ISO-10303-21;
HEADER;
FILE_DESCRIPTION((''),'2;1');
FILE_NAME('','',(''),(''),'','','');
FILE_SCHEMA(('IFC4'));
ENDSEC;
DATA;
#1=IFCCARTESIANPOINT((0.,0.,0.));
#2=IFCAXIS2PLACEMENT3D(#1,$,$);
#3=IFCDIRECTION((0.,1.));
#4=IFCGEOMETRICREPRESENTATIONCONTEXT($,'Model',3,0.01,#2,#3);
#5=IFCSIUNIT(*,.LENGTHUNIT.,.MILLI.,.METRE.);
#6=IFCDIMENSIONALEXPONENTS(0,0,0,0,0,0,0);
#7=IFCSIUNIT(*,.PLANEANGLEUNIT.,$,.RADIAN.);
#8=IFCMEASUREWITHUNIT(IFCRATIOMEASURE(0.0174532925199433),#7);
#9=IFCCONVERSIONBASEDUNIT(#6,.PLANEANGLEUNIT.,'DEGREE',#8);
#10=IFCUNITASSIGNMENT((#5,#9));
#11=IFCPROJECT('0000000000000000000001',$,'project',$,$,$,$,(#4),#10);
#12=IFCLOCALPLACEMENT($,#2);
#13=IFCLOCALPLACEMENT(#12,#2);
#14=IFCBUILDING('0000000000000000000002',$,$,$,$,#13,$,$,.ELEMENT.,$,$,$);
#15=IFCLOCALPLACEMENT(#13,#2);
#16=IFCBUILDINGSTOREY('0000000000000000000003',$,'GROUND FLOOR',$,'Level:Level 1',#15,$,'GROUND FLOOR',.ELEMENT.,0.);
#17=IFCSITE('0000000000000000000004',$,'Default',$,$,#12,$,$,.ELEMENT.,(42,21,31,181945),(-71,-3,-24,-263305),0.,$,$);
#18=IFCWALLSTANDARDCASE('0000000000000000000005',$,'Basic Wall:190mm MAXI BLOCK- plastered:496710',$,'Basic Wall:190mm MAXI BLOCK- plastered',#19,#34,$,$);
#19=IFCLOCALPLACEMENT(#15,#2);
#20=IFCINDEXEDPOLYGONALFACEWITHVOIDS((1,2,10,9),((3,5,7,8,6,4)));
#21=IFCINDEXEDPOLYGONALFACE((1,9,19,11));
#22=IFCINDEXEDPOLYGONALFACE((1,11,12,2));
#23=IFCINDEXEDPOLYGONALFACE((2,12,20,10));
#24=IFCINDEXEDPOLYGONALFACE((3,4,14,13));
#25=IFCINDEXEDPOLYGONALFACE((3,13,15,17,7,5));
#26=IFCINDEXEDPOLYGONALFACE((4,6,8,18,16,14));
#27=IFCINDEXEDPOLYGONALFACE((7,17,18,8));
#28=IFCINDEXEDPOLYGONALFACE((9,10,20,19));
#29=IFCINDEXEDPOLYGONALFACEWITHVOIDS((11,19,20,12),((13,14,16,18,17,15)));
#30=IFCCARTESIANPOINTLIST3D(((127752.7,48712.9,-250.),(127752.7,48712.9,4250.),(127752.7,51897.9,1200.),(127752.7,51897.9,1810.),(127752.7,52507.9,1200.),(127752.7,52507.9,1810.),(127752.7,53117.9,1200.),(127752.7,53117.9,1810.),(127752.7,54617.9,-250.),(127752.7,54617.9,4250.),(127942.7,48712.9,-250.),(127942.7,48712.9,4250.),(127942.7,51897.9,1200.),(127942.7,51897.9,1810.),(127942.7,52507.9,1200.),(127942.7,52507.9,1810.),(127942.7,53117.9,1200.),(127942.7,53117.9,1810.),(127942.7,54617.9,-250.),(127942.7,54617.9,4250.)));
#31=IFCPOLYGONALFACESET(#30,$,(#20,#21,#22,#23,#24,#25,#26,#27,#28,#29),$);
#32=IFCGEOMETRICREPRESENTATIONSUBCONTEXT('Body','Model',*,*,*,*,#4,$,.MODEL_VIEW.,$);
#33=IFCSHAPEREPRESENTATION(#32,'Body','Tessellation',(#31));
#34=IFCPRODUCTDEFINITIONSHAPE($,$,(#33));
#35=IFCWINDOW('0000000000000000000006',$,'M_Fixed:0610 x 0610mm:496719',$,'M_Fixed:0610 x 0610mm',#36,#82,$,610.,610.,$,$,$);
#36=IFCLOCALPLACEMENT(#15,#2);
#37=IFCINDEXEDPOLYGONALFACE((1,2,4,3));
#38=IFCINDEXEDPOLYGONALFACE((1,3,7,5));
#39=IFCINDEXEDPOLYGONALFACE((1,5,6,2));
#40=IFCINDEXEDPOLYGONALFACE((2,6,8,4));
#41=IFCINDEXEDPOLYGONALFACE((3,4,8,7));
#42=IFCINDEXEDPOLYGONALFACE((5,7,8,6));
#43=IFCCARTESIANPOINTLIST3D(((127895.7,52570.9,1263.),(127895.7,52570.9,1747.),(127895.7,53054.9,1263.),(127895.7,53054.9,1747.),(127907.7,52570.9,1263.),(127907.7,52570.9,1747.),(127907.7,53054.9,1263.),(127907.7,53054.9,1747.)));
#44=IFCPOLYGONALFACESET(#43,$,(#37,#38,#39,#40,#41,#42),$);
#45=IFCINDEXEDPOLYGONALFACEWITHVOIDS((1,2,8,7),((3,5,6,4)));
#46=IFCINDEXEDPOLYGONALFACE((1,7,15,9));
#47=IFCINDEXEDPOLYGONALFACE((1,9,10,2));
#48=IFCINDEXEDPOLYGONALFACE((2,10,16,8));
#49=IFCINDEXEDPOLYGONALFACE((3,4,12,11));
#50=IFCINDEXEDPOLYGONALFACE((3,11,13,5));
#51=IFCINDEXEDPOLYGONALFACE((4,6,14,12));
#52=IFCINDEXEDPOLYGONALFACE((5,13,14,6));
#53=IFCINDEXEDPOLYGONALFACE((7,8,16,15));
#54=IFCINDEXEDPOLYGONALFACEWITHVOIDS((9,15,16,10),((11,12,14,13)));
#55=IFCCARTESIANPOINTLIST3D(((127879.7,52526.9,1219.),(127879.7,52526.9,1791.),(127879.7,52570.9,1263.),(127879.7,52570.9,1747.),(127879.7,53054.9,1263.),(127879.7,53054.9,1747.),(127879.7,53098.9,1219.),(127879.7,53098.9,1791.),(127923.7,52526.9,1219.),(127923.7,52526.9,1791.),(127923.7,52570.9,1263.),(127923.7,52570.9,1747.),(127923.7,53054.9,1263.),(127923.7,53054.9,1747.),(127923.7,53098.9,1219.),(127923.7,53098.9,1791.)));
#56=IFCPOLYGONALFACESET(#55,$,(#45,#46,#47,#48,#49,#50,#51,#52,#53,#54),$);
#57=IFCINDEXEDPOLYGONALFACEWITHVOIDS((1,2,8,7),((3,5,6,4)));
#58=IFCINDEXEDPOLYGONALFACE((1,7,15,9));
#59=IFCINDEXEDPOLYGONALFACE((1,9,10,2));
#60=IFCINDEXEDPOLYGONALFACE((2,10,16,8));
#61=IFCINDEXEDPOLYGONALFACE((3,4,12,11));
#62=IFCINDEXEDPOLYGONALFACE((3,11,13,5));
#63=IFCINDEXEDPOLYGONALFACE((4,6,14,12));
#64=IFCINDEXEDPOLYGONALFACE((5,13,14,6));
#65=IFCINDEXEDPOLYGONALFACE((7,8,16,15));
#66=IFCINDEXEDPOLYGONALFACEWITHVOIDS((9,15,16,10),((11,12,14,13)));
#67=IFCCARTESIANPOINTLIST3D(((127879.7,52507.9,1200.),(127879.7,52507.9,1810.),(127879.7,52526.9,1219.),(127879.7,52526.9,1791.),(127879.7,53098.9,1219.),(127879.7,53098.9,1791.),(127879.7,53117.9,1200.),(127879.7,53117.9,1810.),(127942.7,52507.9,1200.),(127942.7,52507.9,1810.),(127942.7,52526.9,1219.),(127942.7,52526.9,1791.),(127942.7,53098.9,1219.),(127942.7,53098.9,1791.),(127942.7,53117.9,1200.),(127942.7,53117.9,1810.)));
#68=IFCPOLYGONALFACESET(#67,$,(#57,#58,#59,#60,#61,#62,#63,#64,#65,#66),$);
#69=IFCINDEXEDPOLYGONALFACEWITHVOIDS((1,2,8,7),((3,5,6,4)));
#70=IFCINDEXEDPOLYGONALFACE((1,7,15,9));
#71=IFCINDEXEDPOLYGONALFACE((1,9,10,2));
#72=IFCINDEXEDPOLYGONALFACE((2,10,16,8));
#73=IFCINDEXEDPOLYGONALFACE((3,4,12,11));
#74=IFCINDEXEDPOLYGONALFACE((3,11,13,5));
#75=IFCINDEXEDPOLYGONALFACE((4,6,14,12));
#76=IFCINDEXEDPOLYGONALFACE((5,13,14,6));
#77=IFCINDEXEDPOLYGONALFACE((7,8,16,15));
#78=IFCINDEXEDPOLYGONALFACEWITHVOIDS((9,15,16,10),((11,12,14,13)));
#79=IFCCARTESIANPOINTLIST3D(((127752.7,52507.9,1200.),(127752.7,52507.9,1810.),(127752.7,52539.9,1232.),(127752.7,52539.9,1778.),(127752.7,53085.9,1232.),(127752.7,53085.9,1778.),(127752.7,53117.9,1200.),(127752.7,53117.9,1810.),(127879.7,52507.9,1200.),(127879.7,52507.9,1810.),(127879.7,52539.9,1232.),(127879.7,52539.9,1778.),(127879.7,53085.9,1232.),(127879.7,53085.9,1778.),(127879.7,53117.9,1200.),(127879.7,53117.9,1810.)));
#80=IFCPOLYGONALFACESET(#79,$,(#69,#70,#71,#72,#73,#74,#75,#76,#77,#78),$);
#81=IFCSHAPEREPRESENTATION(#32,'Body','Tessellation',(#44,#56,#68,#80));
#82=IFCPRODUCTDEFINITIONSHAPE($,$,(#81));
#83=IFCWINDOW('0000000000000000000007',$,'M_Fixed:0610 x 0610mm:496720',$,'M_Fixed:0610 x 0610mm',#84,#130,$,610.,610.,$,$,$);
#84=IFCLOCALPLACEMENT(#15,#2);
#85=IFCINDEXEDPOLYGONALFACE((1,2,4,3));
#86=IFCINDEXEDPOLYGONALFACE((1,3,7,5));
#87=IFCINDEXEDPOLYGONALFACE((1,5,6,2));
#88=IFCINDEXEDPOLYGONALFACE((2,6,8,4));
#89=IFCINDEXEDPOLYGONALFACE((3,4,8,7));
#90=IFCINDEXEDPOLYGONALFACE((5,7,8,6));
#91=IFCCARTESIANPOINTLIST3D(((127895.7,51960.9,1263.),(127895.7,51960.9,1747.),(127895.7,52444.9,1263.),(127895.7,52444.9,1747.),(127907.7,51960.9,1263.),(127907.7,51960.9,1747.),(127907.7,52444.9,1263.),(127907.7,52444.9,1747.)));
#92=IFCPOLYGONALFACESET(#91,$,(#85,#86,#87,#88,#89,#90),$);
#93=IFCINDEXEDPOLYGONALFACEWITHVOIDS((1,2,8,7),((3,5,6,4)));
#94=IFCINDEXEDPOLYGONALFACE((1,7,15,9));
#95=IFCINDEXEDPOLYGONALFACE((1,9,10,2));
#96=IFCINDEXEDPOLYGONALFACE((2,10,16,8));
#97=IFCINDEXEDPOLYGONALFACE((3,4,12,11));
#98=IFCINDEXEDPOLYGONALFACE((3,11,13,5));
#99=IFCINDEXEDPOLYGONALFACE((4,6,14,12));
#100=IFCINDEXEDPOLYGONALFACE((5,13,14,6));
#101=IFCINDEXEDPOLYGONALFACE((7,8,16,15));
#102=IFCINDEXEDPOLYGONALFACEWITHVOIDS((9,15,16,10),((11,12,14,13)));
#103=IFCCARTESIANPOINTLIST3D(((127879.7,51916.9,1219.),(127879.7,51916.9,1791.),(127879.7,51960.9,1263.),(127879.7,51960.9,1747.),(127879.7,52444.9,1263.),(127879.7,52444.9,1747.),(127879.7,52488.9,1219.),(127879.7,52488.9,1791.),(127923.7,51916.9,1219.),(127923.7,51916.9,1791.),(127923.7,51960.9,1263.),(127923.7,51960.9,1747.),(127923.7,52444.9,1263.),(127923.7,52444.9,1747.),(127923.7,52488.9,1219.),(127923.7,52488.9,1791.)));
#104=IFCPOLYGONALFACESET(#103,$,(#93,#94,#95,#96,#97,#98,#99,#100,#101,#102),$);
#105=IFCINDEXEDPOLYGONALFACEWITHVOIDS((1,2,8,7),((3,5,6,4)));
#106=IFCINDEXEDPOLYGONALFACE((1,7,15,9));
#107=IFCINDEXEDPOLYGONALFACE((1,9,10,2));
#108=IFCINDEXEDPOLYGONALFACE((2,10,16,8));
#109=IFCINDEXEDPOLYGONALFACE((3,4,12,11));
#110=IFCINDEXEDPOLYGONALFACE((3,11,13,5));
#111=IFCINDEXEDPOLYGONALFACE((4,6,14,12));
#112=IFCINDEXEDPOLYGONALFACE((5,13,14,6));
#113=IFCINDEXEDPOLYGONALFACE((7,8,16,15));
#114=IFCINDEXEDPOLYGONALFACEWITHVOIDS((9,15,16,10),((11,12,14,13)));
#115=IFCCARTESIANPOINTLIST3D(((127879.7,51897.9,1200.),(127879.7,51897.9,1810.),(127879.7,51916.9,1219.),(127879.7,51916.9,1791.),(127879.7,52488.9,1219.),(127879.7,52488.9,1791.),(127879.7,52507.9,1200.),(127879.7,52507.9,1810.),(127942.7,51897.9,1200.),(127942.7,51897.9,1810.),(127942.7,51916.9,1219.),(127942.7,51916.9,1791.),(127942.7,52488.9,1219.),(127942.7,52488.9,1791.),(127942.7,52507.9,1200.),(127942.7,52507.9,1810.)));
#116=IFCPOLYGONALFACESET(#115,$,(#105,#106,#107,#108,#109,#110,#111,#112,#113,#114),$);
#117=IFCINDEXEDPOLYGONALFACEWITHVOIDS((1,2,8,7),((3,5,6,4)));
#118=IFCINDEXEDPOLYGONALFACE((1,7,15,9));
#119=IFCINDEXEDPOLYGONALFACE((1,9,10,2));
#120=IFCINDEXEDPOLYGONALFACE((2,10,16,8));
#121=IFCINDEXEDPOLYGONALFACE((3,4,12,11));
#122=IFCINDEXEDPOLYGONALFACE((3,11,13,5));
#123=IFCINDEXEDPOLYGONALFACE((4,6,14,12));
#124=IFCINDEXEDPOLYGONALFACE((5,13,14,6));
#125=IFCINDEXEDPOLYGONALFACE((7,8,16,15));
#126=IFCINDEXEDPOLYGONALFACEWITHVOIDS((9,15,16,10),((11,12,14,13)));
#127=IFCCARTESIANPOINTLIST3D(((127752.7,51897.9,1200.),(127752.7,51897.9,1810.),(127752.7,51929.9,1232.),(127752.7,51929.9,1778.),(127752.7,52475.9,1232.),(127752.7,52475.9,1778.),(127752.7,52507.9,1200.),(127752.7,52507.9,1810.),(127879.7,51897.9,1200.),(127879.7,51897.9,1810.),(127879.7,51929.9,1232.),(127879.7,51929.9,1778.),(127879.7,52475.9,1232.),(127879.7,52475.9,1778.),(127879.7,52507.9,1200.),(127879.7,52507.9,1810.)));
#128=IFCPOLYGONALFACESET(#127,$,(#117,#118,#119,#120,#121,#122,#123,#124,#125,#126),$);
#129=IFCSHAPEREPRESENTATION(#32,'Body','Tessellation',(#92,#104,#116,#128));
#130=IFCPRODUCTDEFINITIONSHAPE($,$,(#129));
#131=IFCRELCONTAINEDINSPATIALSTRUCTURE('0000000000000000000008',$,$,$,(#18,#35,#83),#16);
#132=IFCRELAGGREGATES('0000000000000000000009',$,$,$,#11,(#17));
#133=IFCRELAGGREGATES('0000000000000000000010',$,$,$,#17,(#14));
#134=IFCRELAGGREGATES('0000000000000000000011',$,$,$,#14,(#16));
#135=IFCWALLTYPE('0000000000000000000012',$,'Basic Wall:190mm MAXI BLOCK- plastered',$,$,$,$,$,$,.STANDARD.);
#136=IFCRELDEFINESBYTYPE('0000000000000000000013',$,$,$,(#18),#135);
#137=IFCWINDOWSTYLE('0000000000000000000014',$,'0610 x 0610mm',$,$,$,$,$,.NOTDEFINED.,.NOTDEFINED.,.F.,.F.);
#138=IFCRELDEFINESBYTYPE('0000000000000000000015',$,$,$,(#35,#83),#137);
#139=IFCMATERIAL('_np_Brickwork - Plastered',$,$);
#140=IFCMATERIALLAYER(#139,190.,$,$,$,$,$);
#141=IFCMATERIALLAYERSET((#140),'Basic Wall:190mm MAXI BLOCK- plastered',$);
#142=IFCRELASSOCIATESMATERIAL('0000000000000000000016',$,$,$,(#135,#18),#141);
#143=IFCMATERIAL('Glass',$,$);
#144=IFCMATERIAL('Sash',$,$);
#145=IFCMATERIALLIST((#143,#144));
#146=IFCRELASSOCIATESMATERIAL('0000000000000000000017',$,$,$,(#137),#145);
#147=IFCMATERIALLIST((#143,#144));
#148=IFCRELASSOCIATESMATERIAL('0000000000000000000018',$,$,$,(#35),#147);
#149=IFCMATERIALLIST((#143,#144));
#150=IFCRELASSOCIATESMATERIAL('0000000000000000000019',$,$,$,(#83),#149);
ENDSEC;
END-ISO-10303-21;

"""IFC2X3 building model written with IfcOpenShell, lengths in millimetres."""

from ifc_helpers import new_model, entity, si_unit, converted_unit, direction, frame, frame_2d, origin, place, context, subcontext, project, spatial, polyline, rectangle, outline, extrude, source, transform, mapped, material, material_list, layer, layer_set, layer_usage, type_object, type_shapes, element, fill, save


model = new_model("IFC2X3")

# Units and contexts
model_context = context("Model", 3, precision=0.01, world=origin(), true_north=direction((0.0, 1.0)))
body_context = subcontext(model_context, "Body", "Model", "MODEL_VIEW")
ifc_project = project(units=[si_unit("LENGTHUNIT", "METRE", prefix="MILLI"), converted_unit("PLANEANGLEUNIT", "DEGREE", entity("IfcRatioMeasure", 0.0174532925199433), si_unit("PLANEANGLEUNIT", "RADIAN"), dimensions=[0, 0, 0, 0, 0, 0, 0])], contexts=[model_context])

# Site, building, storey
site_placement = place(None, origin())
site = spatial("IfcSite", under=ifc_project, at=site_placement, Name="Default", CompositionType="ELEMENT", RefLatitude=(42, 21, 31, 181945), RefLongitude=(-71, -3, -24, -263305), RefElevation=0.0)
building_placement = place(site_placement, origin())
building = spatial("IfcBuilding", under=site, at=building_placement, CompositionType="ELEMENT")
storey_placement = place(building_placement, origin())
storey = spatial("IfcBuildingStorey", under=building, at=storey_placement, Name="GROUND FLOOR", ObjectType="Level:Level 1", LongName="GROUND FLOOR", CompositionType="ELEMENT", Elevation=0.0)

# Wall, openings, windows
ifc_material_1 = material(Name="_np_Brickwork - Plastered")
ifc_layer = layer(ifc_material_1, 190.0)
ifc_layer_set = layer_set([ifc_layer], Name="Basic Wall:190mm MAXI BLOCK- plastered")
wall_type = type_object("IfcWallType", Name="Basic Wall:190mm MAXI BLOCK- plastered", PredefinedType="STANDARD", material=ifc_layer_set)
ifc_material_2 = material(Name="Glass")
ifc_material_3 = material(Name="Sash")
ifc_material_list_1 = material_list([ifc_material_2, ifc_material_3])
window_style = type_object("IfcWindowStyle", Name="0610 x 0610mm", ConstructionType="NOTDEFINED", OperationType="NOTDEFINED", ParameterTakesPrecedence=False, Sizeable=False, material=ifc_material_list_1)
shared_shape = source(origin(), body_context, "Body", "SweptSolid", [
    extrude(rectangle(XDim=12.0, YDim=484.0, at=frame_2d((0.0, 0.0), x_axis=(1.0, 0.0))), frame((305.0, 149.0, 63.0), z_axis=(0.0, 0.0, 1.0), x_axis=(0.0, -1.0, 0.0)), (0.0, 0.0, 1.0), 484.0),
    extrude(outline(polyline([(-286.0, -286.0), (286.0, -286.0), (286.0, 286.0), (-286.0, 286.0), (-286.0, -286.0)]), holes=[polyline([(-242.0, -242.0), (-242.0, 242.0), (242.0, 242.0), (242.0, -242.0), (-242.0, -242.0)])]), frame((305.0, 127.0, 305.0), z_axis=(0.0, 1.0, 0.0), x_axis=(1.0, 0.0, 0.0)), (0.0, 0.0, 1.0), 44.0),
    extrude(outline(polyline([(-305.0, -305.0), (305.0, -305.0), (305.0, 305.0), (-305.0, 305.0), (-305.0, -305.0)]), holes=[polyline([(-286.0, -286.0), (-286.0, 286.0), (286.0, 286.0), (286.0, -286.0), (-286.0, -286.0)])]), frame((305.0, 127.0, 305.0), z_axis=(0.0, 1.0, 0.0), x_axis=(1.0, 0.0, 0.0)), (0.0, 0.0, 1.0), 63.0),
    extrude(outline(polyline([(-305.0, -305.0), (305.0, -305.0), (305.0, 305.0), (-305.0, 305.0), (-305.0, -305.0)]), holes=[polyline([(-273.0, -273.0), (-273.0, 273.0), (273.0, 273.0), (273.0, -273.0), (-273.0, -273.0)])]), frame((305.0, 0.0, 305.0), z_axis=(0.0, 1.0, 0.0), x_axis=(1.0, 0.0, 0.0)), (0.0, 0.0, 1.0), 127.0),
])
type_shapes(window_style, [shared_shape])
ifc_layer_usage_1 = layer_usage(ifc_layer_set, "AXIS2", "NEGATIVE", 95.0)
wall_1_placement = place(storey_placement, frame((127847.7, 48712.9, -250.0), z_axis=(0.0, 0.0, 1.0), x_axis=(0.0, 1.0, 0.0)))
wall_1 = element("IfcWallStandardCase", 1, at=wall_1_placement, inside=storey, type_object=wall_type, material=ifc_layer_usage_1, Name="Basic Wall:190mm MAXI BLOCK- plastered:496710", ObjectType="Basic Wall:190mm MAXI BLOCK- plastered", context=body_context, shape_type="SweptSolid", body=[
    extrude(rectangle(XDim=5905.0, YDim=190.0, at=frame_2d((2952.5, 0.0), x_axis=(-1.0, 0.0))), origin(), (0.0, 0.0, 1.0), 4500.0),
])
opening_1_placement = place(wall_1_placement, frame((4405.0, 95.0, 1450.0)))
opening_1 = element("IfcOpeningElement", 2, at=opening_1_placement, cuts=wall_1, ObjectType="Opening", context=body_context, shape_type="SweptSolid", body=[
    extrude(rectangle(XDim=610.0, YDim=610.0, at=frame_2d((305.0, 305.0), x_axis=(1.0, 0.0))), frame((0.0, 0.0, 0.0), z_axis=(0.0, -1.0, 0.0), x_axis=(0.0, 0.0, 1.0)), (0.0, 0.0, 1.0), 190.0),
])
opening_2_placement = place(wall_1_placement, frame((3795.0, 95.0, 1450.0)))
opening_2 = element("IfcOpeningElement", 3, at=opening_2_placement, cuts=wall_1, ObjectType="Opening", context=body_context, shape_type="SweptSolid", body=[
    extrude(rectangle(XDim=610.0, YDim=610.0, at=frame_2d((305.0, 305.0), x_axis=(1.0, 0.0))), frame((0.0, 0.0, 0.0), z_axis=(0.0, -1.0, 0.0), x_axis=(0.0, 0.0, 1.0)), (0.0, 0.0, 1.0), 190.0),
])
ifc_material_list_2 = material_list([ifc_material_2, ifc_material_3])
window_1_placement = place(opening_1_placement, frame((0.0, 0.0, 0.0), z_axis=(0.0, 0.0, 1.0), x_axis=(-1.0, 0.0, 0.0)))
window_1 = element("IfcWindow", 4, at=window_1_placement, inside=storey, type_object=window_style, material=ifc_material_list_2, Name="M_Fixed:0610 x 0610mm:496719", ObjectType="M_Fixed:0610 x 0610mm", OverallHeight=610.0, OverallWidth=610.0, context=body_context, shape_type="MappedRepresentation", body=[
    mapped(shared_shape, transform((0.0, 0.0, 0.0), scale=1.0)),
])
fill(opening_1, window_1)
ifc_material_list_3 = material_list([ifc_material_2, ifc_material_3])
window_2_placement = place(opening_2_placement, frame((0.0, 0.0, 0.0), z_axis=(0.0, 0.0, 1.0), x_axis=(-1.0, 0.0, 0.0)))
window_2 = element("IfcWindow", 5, at=window_2_placement, inside=storey, type_object=window_style, material=ifc_material_list_3, Name="M_Fixed:0610 x 0610mm:496720", ObjectType="M_Fixed:0610 x 0610mm", OverallHeight=610.0, OverallWidth=610.0, context=body_context, shape_type="MappedRepresentation", body=[
    mapped(shared_shape, transform((0.0, 0.0, 0.0), scale=1.0)),
])
fill(opening_2, window_2)

save(model, "model.ifc")
